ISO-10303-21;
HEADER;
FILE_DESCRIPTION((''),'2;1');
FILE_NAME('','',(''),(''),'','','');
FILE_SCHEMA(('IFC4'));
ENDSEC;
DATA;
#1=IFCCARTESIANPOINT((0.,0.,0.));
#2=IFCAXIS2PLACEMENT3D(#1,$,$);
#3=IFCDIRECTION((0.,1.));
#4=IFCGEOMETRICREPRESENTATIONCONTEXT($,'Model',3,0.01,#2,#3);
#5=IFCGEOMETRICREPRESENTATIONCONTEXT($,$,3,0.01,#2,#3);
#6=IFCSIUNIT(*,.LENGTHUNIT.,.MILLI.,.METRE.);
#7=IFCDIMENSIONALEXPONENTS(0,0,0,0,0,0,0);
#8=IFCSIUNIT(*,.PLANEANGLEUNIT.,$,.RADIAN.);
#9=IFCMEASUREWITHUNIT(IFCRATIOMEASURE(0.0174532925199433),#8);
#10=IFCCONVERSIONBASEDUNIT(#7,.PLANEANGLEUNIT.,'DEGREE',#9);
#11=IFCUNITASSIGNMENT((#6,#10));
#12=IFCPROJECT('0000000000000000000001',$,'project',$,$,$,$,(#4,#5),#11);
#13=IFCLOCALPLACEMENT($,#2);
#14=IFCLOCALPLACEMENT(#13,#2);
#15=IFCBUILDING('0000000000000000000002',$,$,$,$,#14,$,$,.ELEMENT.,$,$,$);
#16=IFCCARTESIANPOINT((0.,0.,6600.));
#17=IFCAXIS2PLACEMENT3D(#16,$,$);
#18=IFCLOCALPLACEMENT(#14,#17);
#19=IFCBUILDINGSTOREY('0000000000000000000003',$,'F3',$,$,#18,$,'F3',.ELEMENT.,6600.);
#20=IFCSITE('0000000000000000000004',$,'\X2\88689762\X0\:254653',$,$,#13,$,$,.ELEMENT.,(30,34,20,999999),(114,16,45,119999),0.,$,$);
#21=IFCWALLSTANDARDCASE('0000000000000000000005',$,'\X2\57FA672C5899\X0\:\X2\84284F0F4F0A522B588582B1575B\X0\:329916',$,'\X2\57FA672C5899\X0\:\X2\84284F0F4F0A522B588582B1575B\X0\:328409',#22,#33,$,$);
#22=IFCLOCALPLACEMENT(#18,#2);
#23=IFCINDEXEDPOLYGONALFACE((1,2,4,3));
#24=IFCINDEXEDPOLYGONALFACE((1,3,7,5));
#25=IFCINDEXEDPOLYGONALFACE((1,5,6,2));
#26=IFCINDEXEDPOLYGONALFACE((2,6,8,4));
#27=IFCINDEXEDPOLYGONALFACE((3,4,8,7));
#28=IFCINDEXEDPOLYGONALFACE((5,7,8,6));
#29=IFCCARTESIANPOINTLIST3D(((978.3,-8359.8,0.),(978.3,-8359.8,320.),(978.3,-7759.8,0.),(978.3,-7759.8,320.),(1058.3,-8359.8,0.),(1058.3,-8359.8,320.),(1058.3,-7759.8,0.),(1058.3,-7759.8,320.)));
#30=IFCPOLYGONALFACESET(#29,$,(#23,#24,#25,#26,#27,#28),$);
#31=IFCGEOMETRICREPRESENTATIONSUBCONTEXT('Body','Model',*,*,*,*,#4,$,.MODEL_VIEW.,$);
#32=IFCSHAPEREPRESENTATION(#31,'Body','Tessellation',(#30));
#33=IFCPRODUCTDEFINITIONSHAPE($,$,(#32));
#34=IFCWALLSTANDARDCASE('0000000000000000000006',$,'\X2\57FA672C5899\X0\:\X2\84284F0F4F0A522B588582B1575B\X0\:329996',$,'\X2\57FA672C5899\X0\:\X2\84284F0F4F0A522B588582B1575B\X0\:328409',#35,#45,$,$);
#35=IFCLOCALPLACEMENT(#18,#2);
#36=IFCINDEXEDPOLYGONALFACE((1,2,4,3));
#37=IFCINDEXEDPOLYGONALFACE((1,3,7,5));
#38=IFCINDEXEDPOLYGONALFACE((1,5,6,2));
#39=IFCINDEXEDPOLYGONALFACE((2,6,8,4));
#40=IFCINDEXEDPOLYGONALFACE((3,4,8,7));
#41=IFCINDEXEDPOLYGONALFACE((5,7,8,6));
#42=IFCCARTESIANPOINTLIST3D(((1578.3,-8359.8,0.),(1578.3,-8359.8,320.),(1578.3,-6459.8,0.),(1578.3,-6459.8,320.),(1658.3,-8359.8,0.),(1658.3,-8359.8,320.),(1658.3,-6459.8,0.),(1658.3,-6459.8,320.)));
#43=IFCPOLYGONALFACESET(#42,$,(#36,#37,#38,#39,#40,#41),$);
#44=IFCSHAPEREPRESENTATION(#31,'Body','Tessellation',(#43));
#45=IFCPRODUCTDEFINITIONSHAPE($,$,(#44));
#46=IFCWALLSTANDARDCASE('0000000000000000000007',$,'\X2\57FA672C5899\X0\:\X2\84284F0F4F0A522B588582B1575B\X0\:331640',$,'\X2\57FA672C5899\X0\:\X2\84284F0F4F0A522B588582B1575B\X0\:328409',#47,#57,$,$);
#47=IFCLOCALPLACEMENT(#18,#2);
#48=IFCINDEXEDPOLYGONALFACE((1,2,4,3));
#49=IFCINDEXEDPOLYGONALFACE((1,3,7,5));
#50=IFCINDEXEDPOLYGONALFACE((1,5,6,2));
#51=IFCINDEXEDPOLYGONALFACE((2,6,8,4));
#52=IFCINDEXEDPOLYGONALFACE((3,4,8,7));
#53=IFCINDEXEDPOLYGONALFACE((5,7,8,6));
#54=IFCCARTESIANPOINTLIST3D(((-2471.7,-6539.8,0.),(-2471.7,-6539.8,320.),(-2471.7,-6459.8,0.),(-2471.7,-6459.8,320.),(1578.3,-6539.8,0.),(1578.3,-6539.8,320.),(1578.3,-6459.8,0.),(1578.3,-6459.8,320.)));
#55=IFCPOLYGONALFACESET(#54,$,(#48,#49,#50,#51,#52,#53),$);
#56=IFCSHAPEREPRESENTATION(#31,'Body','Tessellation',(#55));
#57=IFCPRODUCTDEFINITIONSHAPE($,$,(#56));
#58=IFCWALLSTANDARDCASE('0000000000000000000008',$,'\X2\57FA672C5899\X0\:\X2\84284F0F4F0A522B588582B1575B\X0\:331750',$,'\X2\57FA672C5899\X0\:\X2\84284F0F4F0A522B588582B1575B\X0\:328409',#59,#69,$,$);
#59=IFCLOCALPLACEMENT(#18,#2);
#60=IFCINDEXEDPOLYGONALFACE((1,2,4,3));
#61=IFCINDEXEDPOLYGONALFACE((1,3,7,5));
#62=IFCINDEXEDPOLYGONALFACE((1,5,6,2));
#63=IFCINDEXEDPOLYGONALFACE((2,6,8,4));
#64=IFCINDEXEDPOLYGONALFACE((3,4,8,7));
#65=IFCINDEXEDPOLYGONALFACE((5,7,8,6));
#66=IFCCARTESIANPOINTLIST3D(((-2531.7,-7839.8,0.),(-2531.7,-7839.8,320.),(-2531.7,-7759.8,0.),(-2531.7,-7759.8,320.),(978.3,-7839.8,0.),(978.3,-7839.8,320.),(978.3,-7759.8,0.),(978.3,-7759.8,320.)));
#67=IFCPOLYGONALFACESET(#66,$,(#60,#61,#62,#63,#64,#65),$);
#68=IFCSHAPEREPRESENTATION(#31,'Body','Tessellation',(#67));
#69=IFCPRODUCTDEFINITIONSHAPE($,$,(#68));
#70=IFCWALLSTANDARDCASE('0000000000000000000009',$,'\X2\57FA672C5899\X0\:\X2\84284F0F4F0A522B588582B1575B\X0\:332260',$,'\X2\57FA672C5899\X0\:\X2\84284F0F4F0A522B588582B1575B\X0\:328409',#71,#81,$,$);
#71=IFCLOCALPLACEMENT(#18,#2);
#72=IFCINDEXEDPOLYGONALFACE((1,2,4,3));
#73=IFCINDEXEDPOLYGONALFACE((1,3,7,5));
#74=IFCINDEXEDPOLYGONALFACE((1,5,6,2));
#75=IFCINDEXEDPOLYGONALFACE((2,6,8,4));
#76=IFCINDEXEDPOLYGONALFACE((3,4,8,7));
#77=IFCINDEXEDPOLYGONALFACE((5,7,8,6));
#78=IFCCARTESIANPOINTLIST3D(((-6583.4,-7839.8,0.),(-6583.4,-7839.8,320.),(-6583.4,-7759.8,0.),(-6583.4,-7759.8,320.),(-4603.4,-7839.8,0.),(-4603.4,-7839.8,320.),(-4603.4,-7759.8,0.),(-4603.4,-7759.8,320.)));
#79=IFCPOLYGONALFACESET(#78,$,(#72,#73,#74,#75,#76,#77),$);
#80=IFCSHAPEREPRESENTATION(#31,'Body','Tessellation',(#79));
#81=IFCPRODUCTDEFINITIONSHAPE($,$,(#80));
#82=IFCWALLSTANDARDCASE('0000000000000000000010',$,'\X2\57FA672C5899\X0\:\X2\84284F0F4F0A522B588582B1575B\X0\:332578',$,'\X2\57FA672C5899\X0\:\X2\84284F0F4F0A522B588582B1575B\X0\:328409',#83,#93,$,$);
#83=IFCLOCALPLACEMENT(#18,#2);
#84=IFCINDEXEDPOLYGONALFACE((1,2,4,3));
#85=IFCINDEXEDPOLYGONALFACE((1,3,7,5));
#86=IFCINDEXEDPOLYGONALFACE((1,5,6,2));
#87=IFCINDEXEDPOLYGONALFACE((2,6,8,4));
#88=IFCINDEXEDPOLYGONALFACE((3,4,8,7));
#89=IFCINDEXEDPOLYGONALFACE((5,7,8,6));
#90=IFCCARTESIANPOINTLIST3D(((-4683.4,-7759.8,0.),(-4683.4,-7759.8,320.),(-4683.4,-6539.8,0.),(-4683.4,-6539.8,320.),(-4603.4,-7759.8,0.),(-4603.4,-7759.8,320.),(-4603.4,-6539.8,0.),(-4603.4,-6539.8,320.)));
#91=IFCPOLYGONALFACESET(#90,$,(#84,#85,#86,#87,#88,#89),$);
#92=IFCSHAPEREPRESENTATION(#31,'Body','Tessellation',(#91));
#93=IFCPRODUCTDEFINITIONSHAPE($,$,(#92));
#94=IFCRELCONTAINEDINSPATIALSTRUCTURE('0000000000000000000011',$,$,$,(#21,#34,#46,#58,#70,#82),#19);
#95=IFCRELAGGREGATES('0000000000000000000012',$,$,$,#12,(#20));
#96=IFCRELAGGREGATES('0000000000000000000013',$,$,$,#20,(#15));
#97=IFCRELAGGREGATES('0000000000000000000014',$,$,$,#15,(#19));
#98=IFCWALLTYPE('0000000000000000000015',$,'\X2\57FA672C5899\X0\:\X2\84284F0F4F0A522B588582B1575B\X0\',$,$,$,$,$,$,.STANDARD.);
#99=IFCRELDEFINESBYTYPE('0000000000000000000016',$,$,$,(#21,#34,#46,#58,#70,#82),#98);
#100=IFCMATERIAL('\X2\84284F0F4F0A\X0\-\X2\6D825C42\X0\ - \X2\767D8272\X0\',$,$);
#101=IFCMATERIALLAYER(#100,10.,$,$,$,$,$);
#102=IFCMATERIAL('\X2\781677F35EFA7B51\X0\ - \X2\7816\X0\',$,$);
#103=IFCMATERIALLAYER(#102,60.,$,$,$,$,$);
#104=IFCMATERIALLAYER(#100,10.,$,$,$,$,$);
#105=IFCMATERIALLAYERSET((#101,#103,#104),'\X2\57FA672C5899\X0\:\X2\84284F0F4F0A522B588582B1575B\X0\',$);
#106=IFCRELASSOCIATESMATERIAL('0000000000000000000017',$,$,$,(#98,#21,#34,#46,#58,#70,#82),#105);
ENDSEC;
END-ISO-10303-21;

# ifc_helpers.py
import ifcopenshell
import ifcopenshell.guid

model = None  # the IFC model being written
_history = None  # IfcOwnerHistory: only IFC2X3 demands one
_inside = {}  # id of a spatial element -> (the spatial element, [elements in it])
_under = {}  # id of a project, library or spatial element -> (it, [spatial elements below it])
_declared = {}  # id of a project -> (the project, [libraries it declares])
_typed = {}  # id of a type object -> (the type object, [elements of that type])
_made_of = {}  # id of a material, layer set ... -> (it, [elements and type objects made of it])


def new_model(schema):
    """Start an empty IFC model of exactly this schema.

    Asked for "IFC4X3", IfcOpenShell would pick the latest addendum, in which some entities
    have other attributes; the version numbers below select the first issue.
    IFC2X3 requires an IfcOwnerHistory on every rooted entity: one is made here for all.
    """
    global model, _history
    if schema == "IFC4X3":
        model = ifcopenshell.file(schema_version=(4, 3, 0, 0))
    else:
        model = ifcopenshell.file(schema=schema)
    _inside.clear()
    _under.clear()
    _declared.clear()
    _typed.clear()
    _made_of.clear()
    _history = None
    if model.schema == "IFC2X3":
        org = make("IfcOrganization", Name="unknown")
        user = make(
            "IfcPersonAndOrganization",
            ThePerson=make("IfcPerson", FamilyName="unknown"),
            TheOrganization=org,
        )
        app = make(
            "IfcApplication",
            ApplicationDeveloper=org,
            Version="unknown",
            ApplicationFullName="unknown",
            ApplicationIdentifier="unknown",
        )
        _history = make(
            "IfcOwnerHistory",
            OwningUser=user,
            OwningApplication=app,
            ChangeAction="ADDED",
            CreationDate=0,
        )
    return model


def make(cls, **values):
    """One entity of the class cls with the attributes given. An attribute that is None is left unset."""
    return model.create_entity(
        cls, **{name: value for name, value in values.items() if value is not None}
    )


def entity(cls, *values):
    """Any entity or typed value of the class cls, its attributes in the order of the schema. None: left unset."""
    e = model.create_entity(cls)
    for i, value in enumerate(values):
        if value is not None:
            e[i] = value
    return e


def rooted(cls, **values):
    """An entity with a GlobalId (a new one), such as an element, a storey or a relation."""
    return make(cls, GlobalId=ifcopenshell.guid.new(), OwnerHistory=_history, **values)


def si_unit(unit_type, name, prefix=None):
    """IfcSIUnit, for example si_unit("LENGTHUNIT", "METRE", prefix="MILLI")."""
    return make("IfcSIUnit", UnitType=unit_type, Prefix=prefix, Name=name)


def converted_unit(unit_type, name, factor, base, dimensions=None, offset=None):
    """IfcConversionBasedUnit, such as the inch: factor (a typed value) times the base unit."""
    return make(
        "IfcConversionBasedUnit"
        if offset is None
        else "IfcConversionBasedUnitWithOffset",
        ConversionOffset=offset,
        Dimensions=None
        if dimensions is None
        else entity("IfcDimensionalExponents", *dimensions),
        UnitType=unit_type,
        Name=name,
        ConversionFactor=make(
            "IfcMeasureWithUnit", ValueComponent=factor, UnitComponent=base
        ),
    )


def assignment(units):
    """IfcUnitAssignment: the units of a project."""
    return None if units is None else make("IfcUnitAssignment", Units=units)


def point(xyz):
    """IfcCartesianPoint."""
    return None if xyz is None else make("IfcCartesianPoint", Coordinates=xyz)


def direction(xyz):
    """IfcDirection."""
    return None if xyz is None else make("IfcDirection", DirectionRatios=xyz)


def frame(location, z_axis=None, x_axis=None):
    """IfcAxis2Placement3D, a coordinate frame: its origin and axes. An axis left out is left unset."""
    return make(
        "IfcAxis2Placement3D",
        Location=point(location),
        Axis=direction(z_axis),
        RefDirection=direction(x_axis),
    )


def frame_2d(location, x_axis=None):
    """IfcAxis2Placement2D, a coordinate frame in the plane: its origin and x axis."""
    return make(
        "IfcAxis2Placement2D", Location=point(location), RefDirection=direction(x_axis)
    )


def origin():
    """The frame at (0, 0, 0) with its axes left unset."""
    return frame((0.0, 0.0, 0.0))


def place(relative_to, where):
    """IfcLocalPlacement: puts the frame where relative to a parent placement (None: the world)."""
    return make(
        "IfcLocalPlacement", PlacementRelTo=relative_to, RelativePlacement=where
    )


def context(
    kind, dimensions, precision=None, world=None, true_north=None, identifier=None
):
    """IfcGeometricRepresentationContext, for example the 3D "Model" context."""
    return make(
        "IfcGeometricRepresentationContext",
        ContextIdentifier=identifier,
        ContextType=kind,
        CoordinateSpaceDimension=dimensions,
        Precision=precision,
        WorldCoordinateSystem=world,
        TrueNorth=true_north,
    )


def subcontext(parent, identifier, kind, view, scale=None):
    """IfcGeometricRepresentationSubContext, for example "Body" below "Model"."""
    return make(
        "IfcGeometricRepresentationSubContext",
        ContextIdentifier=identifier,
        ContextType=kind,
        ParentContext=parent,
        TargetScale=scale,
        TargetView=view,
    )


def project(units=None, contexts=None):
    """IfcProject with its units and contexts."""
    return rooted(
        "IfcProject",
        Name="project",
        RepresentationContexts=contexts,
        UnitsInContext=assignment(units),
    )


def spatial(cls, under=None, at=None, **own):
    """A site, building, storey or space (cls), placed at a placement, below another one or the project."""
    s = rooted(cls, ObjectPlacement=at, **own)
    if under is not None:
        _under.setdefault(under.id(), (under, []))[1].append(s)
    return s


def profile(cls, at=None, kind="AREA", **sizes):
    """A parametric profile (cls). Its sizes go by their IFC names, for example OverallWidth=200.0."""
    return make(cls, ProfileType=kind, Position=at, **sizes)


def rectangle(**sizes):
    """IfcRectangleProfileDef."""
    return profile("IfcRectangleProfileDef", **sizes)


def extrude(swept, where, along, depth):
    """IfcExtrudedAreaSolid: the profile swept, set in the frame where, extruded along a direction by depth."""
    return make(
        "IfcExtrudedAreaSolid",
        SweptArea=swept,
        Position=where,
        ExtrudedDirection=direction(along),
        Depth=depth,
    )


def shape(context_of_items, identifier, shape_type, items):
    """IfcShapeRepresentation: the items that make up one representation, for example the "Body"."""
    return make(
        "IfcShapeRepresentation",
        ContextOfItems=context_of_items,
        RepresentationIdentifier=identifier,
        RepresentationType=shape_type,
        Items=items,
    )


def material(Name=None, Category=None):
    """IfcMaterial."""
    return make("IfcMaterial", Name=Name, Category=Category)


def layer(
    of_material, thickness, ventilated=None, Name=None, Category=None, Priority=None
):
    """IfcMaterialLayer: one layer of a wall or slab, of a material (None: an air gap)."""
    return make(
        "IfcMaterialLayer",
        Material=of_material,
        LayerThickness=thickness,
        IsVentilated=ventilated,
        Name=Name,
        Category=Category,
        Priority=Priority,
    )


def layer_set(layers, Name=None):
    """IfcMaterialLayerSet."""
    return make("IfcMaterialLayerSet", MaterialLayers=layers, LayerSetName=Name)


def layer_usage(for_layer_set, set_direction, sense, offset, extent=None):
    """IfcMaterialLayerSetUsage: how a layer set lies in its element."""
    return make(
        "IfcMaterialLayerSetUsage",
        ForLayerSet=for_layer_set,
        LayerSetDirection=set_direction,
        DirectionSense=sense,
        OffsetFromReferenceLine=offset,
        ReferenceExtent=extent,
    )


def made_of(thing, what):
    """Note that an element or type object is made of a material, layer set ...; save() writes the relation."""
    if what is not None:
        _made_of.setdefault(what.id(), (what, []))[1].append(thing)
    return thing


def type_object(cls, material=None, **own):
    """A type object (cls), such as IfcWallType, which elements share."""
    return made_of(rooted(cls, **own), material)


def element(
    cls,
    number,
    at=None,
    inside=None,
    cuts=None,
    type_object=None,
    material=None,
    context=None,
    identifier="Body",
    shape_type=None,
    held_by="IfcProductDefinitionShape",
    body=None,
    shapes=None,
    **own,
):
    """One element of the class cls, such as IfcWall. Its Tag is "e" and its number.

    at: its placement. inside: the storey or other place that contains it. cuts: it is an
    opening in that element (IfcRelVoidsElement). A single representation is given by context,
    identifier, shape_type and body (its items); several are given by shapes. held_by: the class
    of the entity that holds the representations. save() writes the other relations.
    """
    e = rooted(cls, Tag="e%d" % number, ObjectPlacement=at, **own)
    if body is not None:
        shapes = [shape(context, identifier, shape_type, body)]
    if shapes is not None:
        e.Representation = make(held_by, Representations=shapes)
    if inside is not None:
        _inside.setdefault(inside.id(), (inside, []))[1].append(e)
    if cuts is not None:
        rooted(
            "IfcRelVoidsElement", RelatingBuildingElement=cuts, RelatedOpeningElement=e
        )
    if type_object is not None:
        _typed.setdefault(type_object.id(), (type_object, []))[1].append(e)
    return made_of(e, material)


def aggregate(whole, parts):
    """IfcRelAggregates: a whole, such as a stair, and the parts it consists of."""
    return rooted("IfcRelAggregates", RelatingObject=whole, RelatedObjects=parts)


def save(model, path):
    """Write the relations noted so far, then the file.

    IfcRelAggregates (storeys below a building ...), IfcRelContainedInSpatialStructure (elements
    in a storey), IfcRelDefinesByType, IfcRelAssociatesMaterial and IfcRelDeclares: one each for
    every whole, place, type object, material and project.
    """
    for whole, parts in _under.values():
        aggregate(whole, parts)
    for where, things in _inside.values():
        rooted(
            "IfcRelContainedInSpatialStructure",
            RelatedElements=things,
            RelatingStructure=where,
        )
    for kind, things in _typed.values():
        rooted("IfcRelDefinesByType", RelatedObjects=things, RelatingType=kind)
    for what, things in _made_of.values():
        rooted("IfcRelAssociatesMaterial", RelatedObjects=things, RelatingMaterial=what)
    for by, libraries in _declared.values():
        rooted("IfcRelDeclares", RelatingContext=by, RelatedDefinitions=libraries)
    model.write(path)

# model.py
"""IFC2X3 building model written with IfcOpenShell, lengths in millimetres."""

from ifc_helpers import new_model, entity, si_unit, converted_unit, direction, frame, frame_2d, origin, place, context, subcontext, project, spatial, rectangle, extrude, material, layer, layer_set, layer_usage, type_object, element, save


model = new_model("IFC2X3")

# Units and contexts
model_context = context("Model", 3, precision=0.01, world=origin(), true_north=direction((0.0, 1.0)))
context_of_model = context(None, 3, precision=0.01, world=origin(), true_north=direction((0.0, 1.0)))
body_context = subcontext(model_context, "Body", "Model", "MODEL_VIEW")
ifc_project = project(units=[si_unit("LENGTHUNIT", "METRE", prefix="MILLI"), converted_unit("PLANEANGLEUNIT", "DEGREE", entity("IfcRatioMeasure", 0.0174532925199433), si_unit("PLANEANGLEUNIT", "RADIAN"), dimensions=[0, 0, 0, 0, 0, 0, 0])], contexts=[model_context, context_of_model])

# Site, building, storey
site_placement = place(None, origin())
site = spatial("IfcSite", under=ifc_project, at=site_placement, Name="表面:254653", CompositionType="ELEMENT", RefLatitude=(30, 34, 20, 999999), RefLongitude=(114, 16, 45, 119999), RefElevation=0.0)
building_placement = place(site_placement, origin())
building = spatial("IfcBuilding", under=site, at=building_placement, CompositionType="ELEMENT")
storey_placement = place(building_placement, frame((0.0, 0.0, 6600.0)))
storey = spatial("IfcBuildingStorey", under=building, at=storey_placement, Name="F3", LongName="F3", CompositionType="ELEMENT", Elevation=6600.0)

# Shared definitions
ifc_material_1 = material(Name="萨伏伊-涂层 - 白色")

# Shared definitions
ifc_material_2 = material(Name="砖石建筑 - 砖")

# Walls
ifc_layer_1 = layer(ifc_material_1, 10.0)
ifc_layer_2 = layer(ifc_material_2, 60.0)
ifc_layer_3 = layer(ifc_material_1, 10.0)
ifc_layer_set_1 = layer_set([ifc_layer_1, ifc_layer_2, ifc_layer_3], Name="基本墙:萨伏伊别墅花坛")
wall_type_1 = type_object("IfcWallType", Name="基本墙:萨伏伊别墅花坛", PredefinedType="STANDARD", material=ifc_layer_set_1)
ifc_layer_usage_1 = layer_usage(ifc_layer_set_1, "AXIS2", "NEGATIVE", 40.0)
wall_1_placement = place(storey_placement, frame((1018.3, -8359.8, 0.0), z_axis=(0.0, 0.0, 1.0), x_axis=(0.0, 1.0, 0.0)))
element("IfcWallStandardCase", 1, at=wall_1_placement, inside=storey, type_object=wall_type_1, material=ifc_layer_usage_1, Name="基本墙:萨伏伊别墅花坛:329916", ObjectType="基本墙:萨伏伊别墅花坛:328409", context=body_context, shape_type="SweptSolid", body=[
    extrude(rectangle(XDim=600.0, YDim=80.0, at=frame_2d((300.0, 0.0), x_axis=(-1.0, 0.0))), origin(), (0.0, 0.0, 1.0), 320.0),
])
ifc_layer_usage_2 = layer_usage(ifc_layer_set_1, "AXIS2", "NEGATIVE", 40.0)
wall_2_placement = place(storey_placement, frame((1618.3, -8359.8, 0.0), z_axis=(0.0, 0.0, 1.0), x_axis=(0.0, 1.0, 0.0)))
element("IfcWallStandardCase", 2, at=wall_2_placement, inside=storey, type_object=wall_type_1, material=ifc_layer_usage_2, Name="基本墙:萨伏伊别墅花坛:329996", ObjectType="基本墙:萨伏伊别墅花坛:328409", context=body_context, shape_type="SweptSolid", body=[
    extrude(rectangle(XDim=1900.0, YDim=80.0, at=frame_2d((950.0, 0.0), x_axis=(-1.0, 0.0))), origin(), (0.0, 0.0, 1.0), 320.0),
])
ifc_layer_usage_3 = layer_usage(ifc_layer_set_1, "AXIS2", "NEGATIVE", 40.0)
wall_3_placement = place(storey_placement, frame((1578.3, -6499.8, 0.0), z_axis=(0.0, 0.0, 1.0), x_axis=(-1.0, 0.0, 0.0)))
element("IfcWallStandardCase", 3, at=wall_3_placement, inside=storey, type_object=wall_type_1, material=ifc_layer_usage_3, Name="基本墙:萨伏伊别墅花坛:331640", ObjectType="基本墙:萨伏伊别墅花坛:328409", context=body_context, shape_type="SweptSolid", body=[
    extrude(rectangle(XDim=4050.0, YDim=80.0, at=frame_2d((2025.0, 0.0), x_axis=(-1.0, 0.0))), origin(), (0.0, 0.0, 1.0), 320.0),
])
ifc_layer_usage_4 = layer_usage(ifc_layer_set_1, "AXIS2", "NEGATIVE", 40.0)
wall_4_placement = place(storey_placement, frame((978.3, -7799.8, 0.0), z_axis=(0.0, 0.0, 1.0), x_axis=(-1.0, 0.0, 0.0)))
element("IfcWallStandardCase", 4, at=wall_4_placement, inside=storey, type_object=wall_type_1, material=ifc_layer_usage_4, Name="基本墙:萨伏伊别墅花坛:331750", ObjectType="基本墙:萨伏伊别墅花坛:328409", context=body_context, shape_type="SweptSolid", body=[
    extrude(rectangle(XDim=3510.0, YDim=80.0, at=frame_2d((1755.0, 0.0), x_axis=(-1.0, 0.0))), origin(), (0.0, 0.0, 1.0), 320.0),
])
ifc_layer_usage_5 = layer_usage(ifc_layer_set_1, "AXIS2", "NEGATIVE", 40.0)
wall_5_placement = place(storey_placement, frame((-4603.4, -7799.8, 0.0), z_axis=(0.0, 0.0, 1.0), x_axis=(-1.0, 0.0, 0.0)))
element("IfcWallStandardCase", 5, at=wall_5_placement, inside=storey, type_object=wall_type_1, material=ifc_layer_usage_5, Name="基本墙:萨伏伊别墅花坛:332260", ObjectType="基本墙:萨伏伊别墅花坛:328409", context=body_context, shape_type="SweptSolid", body=[
    extrude(rectangle(XDim=1980.0, YDim=80.0, at=frame_2d((990.0, 0.0), x_axis=(-1.0, 0.0))), origin(), (0.0, 0.0, 1.0), 320.0),
])
ifc_layer_usage_6 = layer_usage(ifc_layer_set_1, "AXIS2", "NEGATIVE", 40.0)
wall_6_placement = place(storey_placement, frame((-4643.4, -6539.8, 0.0), z_axis=(0.0, 0.0, 1.0), x_axis=(0.0, -1.0, 0.0)))
element("IfcWallStandardCase", 6, at=wall_6_placement, inside=storey, type_object=wall_type_1, material=ifc_layer_usage_6, Name="基本墙:萨伏伊别墅花坛:332578", ObjectType="基本墙:萨伏伊别墅花坛:328409", context=body_context, shape_type="SweptSolid", body=[
    extrude(rectangle(XDim=1220.0, YDim=80.0, at=frame_2d((610.0, 0.0), x_axis=(-1.0, 0.0))), origin(), (0.0, 0.0, 1.0), 320.0),
])

save(model, "model.ifc")
